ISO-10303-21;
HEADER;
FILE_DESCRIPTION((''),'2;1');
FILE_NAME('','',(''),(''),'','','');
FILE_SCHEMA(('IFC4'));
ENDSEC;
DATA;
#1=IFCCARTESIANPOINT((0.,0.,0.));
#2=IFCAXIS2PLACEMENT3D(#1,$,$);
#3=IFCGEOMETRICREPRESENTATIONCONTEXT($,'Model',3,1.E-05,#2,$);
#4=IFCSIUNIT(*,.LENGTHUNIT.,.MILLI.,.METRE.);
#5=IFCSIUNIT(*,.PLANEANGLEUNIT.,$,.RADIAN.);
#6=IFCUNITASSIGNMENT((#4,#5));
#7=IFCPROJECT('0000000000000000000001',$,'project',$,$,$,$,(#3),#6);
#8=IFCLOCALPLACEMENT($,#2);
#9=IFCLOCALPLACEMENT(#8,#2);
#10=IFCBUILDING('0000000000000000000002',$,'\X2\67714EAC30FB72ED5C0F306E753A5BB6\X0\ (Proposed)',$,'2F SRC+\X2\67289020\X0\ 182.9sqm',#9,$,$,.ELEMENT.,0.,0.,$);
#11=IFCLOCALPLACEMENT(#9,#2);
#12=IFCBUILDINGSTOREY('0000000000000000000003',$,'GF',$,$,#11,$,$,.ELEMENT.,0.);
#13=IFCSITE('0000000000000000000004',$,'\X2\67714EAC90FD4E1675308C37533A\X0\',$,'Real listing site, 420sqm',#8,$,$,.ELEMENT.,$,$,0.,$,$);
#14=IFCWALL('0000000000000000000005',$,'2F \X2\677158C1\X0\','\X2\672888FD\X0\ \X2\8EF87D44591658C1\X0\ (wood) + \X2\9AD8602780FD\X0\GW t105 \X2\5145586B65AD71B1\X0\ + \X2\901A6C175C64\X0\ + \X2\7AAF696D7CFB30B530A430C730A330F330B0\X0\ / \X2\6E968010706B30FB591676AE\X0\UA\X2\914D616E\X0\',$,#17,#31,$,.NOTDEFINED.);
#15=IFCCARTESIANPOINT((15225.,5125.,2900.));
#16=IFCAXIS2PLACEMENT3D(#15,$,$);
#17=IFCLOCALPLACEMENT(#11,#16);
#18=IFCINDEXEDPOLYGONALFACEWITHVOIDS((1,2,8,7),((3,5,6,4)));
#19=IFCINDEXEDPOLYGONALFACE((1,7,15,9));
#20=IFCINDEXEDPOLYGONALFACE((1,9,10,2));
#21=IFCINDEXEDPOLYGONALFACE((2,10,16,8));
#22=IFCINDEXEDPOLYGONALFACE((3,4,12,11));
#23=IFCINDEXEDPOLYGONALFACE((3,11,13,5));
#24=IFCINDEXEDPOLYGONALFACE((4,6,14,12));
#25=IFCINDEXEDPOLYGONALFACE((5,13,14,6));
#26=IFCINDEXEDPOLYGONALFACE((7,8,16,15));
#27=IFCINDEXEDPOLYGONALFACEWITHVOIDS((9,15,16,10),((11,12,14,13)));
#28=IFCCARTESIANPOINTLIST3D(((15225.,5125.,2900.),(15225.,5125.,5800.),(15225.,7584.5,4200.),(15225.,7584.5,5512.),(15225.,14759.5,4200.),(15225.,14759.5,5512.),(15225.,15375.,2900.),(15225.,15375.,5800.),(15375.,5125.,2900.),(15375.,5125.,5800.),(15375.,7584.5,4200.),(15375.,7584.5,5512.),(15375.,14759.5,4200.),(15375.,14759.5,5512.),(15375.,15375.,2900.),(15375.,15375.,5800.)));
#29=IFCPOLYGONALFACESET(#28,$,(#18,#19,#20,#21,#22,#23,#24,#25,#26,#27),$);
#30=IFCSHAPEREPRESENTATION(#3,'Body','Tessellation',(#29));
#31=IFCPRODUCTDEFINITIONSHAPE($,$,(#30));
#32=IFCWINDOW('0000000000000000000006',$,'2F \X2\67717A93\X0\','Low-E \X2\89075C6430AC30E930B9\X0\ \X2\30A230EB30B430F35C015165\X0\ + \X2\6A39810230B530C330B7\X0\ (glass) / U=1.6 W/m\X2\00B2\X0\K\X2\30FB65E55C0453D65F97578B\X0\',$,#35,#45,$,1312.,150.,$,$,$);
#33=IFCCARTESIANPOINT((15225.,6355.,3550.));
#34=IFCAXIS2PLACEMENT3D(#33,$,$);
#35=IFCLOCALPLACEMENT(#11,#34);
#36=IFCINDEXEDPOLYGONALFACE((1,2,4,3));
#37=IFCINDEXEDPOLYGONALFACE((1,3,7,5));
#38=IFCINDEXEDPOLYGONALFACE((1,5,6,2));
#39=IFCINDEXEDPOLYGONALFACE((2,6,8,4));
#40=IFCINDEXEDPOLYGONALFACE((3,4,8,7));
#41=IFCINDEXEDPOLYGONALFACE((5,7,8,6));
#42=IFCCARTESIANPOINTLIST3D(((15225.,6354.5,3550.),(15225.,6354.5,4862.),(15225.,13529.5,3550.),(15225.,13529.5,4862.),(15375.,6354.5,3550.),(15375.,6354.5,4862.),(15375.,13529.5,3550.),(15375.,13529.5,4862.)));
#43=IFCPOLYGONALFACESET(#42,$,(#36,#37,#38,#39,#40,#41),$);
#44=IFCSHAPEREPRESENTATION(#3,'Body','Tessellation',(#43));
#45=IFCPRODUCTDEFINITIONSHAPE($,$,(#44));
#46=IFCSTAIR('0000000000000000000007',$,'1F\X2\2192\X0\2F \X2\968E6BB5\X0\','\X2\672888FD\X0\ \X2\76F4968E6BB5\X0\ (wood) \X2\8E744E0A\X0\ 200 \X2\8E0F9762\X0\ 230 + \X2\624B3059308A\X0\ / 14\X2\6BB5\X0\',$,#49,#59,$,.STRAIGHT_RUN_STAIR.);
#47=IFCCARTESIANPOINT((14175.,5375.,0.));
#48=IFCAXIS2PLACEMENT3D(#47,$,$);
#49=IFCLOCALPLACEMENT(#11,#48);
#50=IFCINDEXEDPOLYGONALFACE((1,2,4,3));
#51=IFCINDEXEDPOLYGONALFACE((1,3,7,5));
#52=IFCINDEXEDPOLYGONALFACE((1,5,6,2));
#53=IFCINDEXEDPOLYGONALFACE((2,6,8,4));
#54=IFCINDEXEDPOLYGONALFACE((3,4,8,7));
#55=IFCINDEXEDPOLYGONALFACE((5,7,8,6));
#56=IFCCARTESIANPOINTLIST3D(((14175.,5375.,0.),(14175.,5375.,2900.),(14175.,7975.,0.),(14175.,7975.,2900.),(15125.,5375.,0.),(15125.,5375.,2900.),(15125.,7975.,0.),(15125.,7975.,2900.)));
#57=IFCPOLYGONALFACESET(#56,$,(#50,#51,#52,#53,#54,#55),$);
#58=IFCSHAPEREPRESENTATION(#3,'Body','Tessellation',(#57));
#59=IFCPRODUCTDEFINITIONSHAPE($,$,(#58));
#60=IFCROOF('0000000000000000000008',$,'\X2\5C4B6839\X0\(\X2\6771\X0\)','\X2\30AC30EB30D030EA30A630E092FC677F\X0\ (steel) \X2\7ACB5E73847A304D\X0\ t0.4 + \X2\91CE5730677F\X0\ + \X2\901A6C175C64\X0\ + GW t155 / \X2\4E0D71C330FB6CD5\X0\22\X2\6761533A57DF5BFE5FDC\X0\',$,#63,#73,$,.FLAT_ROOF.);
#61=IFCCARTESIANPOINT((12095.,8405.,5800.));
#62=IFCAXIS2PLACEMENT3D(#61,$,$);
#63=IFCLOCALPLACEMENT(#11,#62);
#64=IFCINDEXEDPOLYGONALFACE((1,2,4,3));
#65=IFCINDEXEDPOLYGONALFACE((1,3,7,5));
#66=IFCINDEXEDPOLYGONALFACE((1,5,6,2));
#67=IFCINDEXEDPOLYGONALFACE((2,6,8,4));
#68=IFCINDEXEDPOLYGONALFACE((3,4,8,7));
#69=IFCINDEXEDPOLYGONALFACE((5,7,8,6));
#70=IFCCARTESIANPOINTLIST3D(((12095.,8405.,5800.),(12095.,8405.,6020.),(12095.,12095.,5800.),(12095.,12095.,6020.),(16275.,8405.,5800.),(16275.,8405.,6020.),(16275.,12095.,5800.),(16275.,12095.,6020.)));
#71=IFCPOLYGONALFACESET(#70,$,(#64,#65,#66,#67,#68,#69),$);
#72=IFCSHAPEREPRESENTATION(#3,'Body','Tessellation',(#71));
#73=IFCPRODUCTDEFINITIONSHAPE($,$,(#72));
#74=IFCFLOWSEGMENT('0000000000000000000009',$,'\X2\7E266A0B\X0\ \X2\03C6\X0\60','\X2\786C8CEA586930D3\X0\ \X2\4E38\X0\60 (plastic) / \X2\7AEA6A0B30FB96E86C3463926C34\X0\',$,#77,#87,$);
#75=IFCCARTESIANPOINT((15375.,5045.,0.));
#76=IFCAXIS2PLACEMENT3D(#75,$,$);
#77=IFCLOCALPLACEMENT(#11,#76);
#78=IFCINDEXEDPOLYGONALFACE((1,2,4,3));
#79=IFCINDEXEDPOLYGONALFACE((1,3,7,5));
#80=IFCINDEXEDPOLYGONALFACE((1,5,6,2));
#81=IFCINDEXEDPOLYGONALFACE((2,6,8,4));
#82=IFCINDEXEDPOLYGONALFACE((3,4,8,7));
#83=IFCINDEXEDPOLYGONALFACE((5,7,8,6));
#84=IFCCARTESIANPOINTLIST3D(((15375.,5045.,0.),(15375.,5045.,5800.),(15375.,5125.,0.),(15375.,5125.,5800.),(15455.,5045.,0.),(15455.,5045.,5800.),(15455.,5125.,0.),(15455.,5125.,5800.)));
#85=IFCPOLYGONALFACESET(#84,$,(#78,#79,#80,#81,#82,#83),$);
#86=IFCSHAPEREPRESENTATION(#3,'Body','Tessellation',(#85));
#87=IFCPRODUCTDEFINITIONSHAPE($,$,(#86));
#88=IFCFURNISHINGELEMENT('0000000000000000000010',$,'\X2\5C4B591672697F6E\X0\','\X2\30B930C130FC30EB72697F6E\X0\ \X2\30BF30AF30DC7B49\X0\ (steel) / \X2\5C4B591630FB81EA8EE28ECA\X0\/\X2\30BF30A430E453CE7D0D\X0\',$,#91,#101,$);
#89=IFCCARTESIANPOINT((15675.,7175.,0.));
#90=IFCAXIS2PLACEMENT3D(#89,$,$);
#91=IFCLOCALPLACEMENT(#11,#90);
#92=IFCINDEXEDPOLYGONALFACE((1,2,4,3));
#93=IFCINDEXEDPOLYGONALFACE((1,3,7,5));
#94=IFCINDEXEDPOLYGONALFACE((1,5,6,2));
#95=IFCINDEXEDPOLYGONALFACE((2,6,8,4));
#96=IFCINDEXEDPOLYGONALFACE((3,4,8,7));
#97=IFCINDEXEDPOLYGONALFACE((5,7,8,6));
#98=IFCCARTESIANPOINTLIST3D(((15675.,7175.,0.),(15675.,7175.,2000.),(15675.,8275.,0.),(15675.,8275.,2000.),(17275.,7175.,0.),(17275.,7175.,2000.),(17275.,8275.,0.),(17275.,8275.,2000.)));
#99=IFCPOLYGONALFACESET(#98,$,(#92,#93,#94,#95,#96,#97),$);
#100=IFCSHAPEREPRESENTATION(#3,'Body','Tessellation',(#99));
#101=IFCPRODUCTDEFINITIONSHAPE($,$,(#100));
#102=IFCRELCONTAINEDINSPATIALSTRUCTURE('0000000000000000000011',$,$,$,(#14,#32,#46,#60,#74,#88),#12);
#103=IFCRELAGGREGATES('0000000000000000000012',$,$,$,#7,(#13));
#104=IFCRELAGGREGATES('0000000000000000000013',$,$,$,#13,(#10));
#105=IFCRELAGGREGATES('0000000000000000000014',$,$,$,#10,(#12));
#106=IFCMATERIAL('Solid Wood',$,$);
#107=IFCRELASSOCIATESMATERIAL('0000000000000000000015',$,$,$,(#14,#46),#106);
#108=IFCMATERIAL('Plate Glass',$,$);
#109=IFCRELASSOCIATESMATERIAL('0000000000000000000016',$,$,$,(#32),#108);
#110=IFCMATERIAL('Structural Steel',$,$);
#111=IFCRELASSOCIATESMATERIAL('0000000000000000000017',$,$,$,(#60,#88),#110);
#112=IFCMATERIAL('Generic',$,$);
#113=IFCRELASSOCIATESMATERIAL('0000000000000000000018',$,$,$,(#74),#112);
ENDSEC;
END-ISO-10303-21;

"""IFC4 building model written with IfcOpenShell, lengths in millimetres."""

from ifc_helpers import new_model, si_unit, frame, frame_2d, origin, place, context, project, spatial, rectangle, extrude, material, element, fill, save


model = new_model("IFC4")

# Units and contexts
model_context = context("Model", 3, precision=1e-05, world=origin())
ifc_project = project(units=[si_unit("LENGTHUNIT", "METRE", prefix="MILLI"), si_unit("PLANEANGLEUNIT", "RADIAN")], contexts=[model_context])

# Site, building, storey
site_placement = place(None, origin())
site = spatial("IfcSite", under=ifc_project, at=site_placement, Name="東京都世田谷区", ObjectType="Real listing site, 420sqm", CompositionType="ELEMENT", RefElevation=0.0)
building_placement = place(site_placement, origin())
building = spatial("IfcBuilding", under=site, at=building_placement, Name="東京・狭小の町家 (Proposed)", ObjectType="2F SRC+木造 182.9sqm", CompositionType="ELEMENT", ElevationOfRefHeight=0.0, ElevationOfTerrain=0.0)
storey_placement = place(building_placement, origin())
storey = spatial("IfcBuildingStorey", under=building, at=storey_placement, Name="GF", CompositionType="ELEMENT", Elevation=0.0)

# Shared definitions
ifc_material_1 = material(Name="Solid Wood")

# Wall, opening, window
ifc_material_2 = material(Name="Plate Glass")
wall_1_placement = place(storey_placement, frame((15225.0, 5125.0, 2900.0)))
wall_1 = element("IfcWall", 1, at=wall_1_placement, inside=storey, material=ifc_material_1, Name="2F 東壁", Description="木製 軸組外壁 (wood) + 高性能GW t105 充填断熱 + 通気層 + 窯業系サイディング / 準耐火・外皮UA配慮", PredefinedType="NOTDEFINED", context=model_context, shape_type="SweptSolid", body=[
    extrude(rectangle(XDim=150.0, YDim=10250.0, at=frame_2d((75.0, 5125.0))), frame((15225.0, 5125.0, 2900.0)), (0.0, 0.0, 1.0), 2900.0),
])
opening_1_placement = place(storey_placement, frame((15225.0, 6355.0, 3550.0)))
opening_1 = element("IfcOpeningElement", 2, at=opening_1_placement, cuts=wall_1, PredefinedType="NOTDEFINED", context=model_context, shape_type="SweptSolid", body=[
    extrude(rectangle(XDim=150.0, YDim=7175.0, at=frame_2d((75.0, 3587.0))), frame((15225.0, 6355.0, 3550.0)), (0.0, 0.0, 1.0), 1312.0),
])
window_1_placement = place(storey_placement, frame((15225.0, 6355.0, 3550.0)))
window_1 = element("IfcWindow", 3, at=window_1_placement, inside=storey, material=ifc_material_2, Name="2F 東窓", Description="Low-E 複層ガラス アルゴン封入 + 樹脂サッシ (glass) / U=1.6 W/m²K・日射取得型", OverallHeight=1312.0, OverallWidth=150.0, context=model_context, shape_type="SweptSolid", body=[
    extrude(rectangle(XDim=150.0, YDim=7175.0, at=frame_2d((75.0, 3587.0))), frame((15225.0, 6355.0, 3550.0)), (0.0, 0.0, 1.0), 1312.0),
])
fill(opening_1, window_1)

# Stair
stair_placement = place(storey_placement, frame((14175.0, 5375.0, 0.0)))
element("IfcStair", 4, at=stair_placement, inside=storey, material=ifc_material_1, Name="1F→2F 階段", Description="木製 直階段 (wood) 蹴上 200 踏面 230 + 手すり / 14段", PredefinedType="STRAIGHT_RUN_STAIR", context=model_context, shape_type="SweptSolid", body=[
    extrude(rectangle(XDim=950.0, YDim=2600.0, at=frame_2d((475.0, 1300.0))), frame((14175.0, 5375.0, 0.0)), (0.0, 0.0, 1.0), 2900.0),
])

# Roof
ifc_material_3 = material(Name="Structural Steel")
roof_placement = place(storey_placement, frame((12095.0, 8405.0, 5800.0)))
element("IfcRoof", 5, at=roof_placement, inside=storey, material=ifc_material_3, Name="屋根(東)", Description="ガルバリウム鋼板 (steel) 立平葺き t0.4 + 野地板 + 通気層 + GW t155 / 不燃・法22条区域対応", PredefinedType="FLAT_ROOF", context=model_context, shape_type="SweptSolid", body=[
    extrude(rectangle(XDim=4180.0, YDim=3690.0, at=frame_2d((2090.0, 1845.0))), frame((12095.0, 8405.0, 5800.0)), (0.0, 0.0, 1.0), 220.0),
])

# Flow segment
ifc_material_4 = material(Name="Generic")
flow_segment_placement = place(storey_placement, frame((15375.0, 5045.0, 0.0)))
element("IfcFlowSegment", 6, at=flow_segment_placement, inside=storey, material=ifc_material_4, Name="縦樋 φ60", Description="硬質塩ビ 丸60 (plastic) / 竪樋・雨水排水", context=model_context, shape_type="SweptSolid", body=[
    extrude(rectangle(XDim=80.0, YDim=80.0, at=frame_2d((40.0, 40.0))), frame((15375.0, 5045.0, 0.0)), (0.0, 0.0, 1.0), 5800.0),
])

# Furnishing element
furnishing_placement = place(storey_placement, frame((15675.0, 7175.0, 0.0)))
element("IfcFurnishingElement", 7, at=furnishing_placement, inside=storey, material=ifc_material_3, Name="屋外物置", Description="スチール物置 タクボ等 (steel) / 屋外・自転車/タイヤ収納", context=model_context, shape_type="SweptSolid", body=[
    extrude(rectangle(XDim=1600.0, YDim=1100.0, at=frame_2d((800.0, 550.0))), frame((15675.0, 7175.0, 0.0)), (0.0, 0.0, 1.0), 2000.0),
])

save(model, "model.ifc")
